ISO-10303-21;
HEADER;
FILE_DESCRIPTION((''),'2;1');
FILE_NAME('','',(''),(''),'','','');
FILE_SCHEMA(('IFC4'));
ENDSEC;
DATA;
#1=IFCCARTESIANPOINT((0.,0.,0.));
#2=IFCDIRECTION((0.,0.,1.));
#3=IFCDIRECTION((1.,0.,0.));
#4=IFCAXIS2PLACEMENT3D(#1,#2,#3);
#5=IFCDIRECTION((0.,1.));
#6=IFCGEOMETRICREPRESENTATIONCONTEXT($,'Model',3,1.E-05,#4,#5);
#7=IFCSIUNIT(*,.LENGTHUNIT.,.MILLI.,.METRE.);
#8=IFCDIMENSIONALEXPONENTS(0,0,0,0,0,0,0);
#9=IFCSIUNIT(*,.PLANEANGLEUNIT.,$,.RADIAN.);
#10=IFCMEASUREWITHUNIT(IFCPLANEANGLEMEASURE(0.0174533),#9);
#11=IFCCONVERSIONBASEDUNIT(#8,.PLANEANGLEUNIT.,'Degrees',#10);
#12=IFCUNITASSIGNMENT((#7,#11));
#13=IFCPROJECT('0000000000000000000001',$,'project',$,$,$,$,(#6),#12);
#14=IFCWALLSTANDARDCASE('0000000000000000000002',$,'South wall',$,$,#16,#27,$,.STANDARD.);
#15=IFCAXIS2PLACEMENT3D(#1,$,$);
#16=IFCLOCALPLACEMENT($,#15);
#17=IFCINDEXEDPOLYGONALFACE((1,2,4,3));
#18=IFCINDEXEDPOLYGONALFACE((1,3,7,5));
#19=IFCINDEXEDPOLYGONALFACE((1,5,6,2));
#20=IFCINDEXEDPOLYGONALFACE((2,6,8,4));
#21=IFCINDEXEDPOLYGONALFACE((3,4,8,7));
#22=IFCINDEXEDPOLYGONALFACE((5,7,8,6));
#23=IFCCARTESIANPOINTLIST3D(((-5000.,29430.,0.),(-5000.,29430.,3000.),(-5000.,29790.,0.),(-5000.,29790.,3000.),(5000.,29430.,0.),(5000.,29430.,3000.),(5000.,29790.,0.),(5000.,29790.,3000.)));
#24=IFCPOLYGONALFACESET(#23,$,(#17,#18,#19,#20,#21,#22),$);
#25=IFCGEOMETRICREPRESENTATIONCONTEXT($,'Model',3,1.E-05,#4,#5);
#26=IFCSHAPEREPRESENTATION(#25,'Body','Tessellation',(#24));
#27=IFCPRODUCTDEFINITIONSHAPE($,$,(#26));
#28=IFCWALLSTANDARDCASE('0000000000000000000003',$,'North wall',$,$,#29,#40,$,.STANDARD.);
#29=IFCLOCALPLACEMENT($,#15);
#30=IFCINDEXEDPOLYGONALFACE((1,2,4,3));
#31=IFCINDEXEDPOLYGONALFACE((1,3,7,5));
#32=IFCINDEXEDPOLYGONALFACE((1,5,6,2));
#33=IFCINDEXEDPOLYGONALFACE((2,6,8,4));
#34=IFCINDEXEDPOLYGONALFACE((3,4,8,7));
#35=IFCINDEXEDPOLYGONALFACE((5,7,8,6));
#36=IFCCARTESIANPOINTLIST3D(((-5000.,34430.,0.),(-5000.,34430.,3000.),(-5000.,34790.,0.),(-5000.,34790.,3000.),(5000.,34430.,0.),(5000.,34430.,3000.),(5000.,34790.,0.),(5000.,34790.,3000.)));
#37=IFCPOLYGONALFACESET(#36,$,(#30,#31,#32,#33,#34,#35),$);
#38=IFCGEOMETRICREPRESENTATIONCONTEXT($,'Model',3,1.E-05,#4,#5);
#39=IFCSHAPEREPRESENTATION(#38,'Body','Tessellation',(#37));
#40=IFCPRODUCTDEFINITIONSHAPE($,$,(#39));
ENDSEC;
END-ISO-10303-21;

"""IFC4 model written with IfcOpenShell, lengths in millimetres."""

from ifc_helpers import new_model, entity, si_unit, converted_unit, direction, frame, origin_with_axes, place, context, project, polyline, outline, extrude, element, save


model = new_model("IFC4")

# Units and contexts
model_context_1 = context("Model", 3, precision=1e-05, world=origin_with_axes(), true_north=direction((0.0, 1.0)))
model_context_2 = context("Model", 3, precision=1e-05, world=origin_with_axes(), true_north=direction((0.0, 1.0)))
model_context_3 = context("Model", 3, precision=1e-05, world=origin_with_axes(), true_north=direction((0.0, 1.0)))
ifc_project = project(units=[si_unit("LENGTHUNIT", "METRE", prefix="MILLI"), converted_unit("PLANEANGLEUNIT", "Degrees", entity("IfcPlaneAngleMeasure", 0.0174533), si_unit("PLANEANGLEUNIT", "RADIAN"), dimensions=[0, 0, 0, 0, 0, 0, 0])], contexts=[model_context_1])

# Shared definitions
placement_1 = place(None, frame((0.0, 29610.0, 0.0)))

# Walls
wall_1_placement = place(placement_1, origin_with_axes())
element("IfcWallStandardCase", 1, at=wall_1_placement, Name="South wall", PredefinedType="STANDARD", context=model_context_2, shape_type="SweptSolid", body=[
    extrude(outline(polyline([(-5000.0, -180.0), (5000.0, -180.0), (5000.0, 180.0), (-5000.0, 180.0), (-5000.0, -180.0), (-5000.0, -180.0)])), origin_with_axes(), (0.0, 0.0, 1.0), 3000.0),
])
wall_2_placement = place(placement_1, frame((0.0, 5000.0, 0.0), z_axis=(0.0, 0.0, 1.0), x_axis=(1.0, 0.0, 0.0)))
element("IfcWallStandardCase", 2, at=wall_2_placement, Name="North wall", PredefinedType="STANDARD", context=model_context_3, shape_type="SweptSolid", body=[
    extrude(outline(polyline([(-5000.0, -180.0), (5000.0, -180.0), (5000.0, 180.0), (-5000.0, 180.0), (-5000.0, -180.0), (-5000.0, -180.0)])), origin_with_axes(), (0.0, 0.0, 1.0), 3000.0),
])

save(model, "model.ifc")
